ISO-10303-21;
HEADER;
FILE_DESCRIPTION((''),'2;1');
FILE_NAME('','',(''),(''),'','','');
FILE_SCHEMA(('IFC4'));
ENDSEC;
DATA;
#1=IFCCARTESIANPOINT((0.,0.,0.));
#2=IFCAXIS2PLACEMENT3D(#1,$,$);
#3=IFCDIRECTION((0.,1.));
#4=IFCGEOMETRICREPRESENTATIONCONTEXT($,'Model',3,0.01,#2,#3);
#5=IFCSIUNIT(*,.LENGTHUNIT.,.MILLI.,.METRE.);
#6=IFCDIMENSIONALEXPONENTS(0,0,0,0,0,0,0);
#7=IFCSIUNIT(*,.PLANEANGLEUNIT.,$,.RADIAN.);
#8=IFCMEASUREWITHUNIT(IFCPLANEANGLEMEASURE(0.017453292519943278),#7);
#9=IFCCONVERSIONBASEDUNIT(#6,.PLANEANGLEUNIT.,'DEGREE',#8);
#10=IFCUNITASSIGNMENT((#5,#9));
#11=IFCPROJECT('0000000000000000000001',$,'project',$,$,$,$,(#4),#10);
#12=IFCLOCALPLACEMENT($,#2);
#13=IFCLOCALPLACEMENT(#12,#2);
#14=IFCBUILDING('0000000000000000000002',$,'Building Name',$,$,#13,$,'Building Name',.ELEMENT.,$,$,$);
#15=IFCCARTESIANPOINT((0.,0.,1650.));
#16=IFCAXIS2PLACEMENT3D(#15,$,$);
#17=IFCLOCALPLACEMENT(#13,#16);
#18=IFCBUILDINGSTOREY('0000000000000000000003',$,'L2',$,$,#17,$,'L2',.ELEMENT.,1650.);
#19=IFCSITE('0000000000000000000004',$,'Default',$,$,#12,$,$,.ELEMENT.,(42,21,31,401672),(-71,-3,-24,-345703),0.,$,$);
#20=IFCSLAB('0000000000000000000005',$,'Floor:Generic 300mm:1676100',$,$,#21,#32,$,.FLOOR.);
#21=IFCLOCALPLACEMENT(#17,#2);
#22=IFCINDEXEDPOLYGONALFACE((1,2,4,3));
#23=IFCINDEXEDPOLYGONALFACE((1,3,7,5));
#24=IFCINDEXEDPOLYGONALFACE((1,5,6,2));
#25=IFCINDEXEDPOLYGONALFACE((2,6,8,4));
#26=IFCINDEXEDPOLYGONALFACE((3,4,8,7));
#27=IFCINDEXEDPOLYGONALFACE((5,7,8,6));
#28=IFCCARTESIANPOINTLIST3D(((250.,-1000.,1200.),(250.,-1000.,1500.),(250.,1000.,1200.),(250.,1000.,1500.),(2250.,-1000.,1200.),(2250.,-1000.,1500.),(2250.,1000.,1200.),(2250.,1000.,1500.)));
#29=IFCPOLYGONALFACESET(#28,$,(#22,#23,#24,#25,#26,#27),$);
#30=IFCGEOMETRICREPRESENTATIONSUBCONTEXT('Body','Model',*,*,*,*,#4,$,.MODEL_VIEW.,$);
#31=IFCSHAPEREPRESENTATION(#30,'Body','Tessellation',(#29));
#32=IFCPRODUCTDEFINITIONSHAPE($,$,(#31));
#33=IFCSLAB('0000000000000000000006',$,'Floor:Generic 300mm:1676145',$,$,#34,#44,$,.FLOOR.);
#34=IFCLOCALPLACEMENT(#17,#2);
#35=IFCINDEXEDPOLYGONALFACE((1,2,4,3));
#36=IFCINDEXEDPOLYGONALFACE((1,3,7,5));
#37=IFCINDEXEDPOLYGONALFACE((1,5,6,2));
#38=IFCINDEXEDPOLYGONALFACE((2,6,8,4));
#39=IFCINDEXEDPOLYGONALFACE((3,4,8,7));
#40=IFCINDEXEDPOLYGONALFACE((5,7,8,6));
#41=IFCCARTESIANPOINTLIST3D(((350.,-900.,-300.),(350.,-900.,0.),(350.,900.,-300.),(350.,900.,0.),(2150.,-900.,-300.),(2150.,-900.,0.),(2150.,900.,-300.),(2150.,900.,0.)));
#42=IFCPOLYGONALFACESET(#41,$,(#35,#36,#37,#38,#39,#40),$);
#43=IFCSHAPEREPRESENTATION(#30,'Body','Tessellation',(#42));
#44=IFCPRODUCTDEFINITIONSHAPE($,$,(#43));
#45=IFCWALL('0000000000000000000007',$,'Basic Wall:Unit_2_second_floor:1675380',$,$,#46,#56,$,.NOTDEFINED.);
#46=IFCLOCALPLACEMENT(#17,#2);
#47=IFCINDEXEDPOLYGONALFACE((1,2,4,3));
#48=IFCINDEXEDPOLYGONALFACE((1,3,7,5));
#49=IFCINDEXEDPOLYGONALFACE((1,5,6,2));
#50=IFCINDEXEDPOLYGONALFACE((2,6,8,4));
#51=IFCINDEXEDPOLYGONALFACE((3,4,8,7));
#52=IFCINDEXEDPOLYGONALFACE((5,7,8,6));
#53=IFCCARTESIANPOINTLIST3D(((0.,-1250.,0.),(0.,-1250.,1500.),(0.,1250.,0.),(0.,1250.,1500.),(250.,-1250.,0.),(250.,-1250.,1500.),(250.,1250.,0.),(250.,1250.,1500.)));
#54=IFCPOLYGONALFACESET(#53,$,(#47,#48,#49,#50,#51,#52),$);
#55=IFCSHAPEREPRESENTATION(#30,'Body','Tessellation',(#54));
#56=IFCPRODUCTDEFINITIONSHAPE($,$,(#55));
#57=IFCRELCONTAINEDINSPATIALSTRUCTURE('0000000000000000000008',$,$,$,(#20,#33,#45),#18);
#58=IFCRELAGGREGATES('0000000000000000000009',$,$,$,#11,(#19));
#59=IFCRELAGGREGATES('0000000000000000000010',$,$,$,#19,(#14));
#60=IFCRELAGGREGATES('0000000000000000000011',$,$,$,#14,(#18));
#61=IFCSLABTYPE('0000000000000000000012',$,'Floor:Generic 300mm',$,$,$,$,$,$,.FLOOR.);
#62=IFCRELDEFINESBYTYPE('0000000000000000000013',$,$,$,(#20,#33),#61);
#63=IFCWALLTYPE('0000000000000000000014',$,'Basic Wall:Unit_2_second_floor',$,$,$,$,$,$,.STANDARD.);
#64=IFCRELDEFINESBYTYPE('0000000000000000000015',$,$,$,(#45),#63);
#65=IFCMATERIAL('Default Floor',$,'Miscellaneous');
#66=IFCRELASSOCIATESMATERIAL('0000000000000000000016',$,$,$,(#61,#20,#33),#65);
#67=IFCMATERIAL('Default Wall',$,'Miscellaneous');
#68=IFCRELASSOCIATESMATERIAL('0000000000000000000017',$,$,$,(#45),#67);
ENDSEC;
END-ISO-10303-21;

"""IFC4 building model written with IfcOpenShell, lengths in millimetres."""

from ifc_helpers import new_model, entity, si_unit, converted_unit, direction, frame, origin, place, context, subcontext, project, spatial, indexed_curve, outline, extrude, material, type_object, element, save


model = new_model("IFC4")

# Units and contexts
model_context = context("Model", 3, precision=0.01, world=origin(), true_north=direction((0.0, 1.0)))
body_context = subcontext(model_context, "Body", "Model", "MODEL_VIEW")
ifc_project = project(units=[si_unit("LENGTHUNIT", "METRE", prefix="MILLI"), converted_unit("PLANEANGLEUNIT", "DEGREE", entity("IfcPlaneAngleMeasure", 0.017453292519943278), si_unit("PLANEANGLEUNIT", "RADIAN"), dimensions=[0, 0, 0, 0, 0, 0, 0])], contexts=[model_context])

# Site, building, storey
site_placement = place(None, origin())
site = spatial("IfcSite", under=ifc_project, at=site_placement, Name="Default", CompositionType="ELEMENT", RefLatitude=(42, 21, 31, 401672), RefLongitude=(-71, -3, -24, -345703), RefElevation=0.0)
building_placement = place(site_placement, origin())
building = spatial("IfcBuilding", under=site, at=building_placement, Name="Building Name", LongName="Building Name", CompositionType="ELEMENT")
storey_placement = place(building_placement, frame((0.0, 0.0, 1650.0)))
storey = spatial("IfcBuildingStorey", under=building, at=storey_placement, Name="L2", LongName="L2", CompositionType="ELEMENT", Elevation=1650.0)

# Slabs
ifc_material_1 = material(Name="Default Floor", Category="Miscellaneous")
slab_type = type_object("IfcSlabType", Name="Floor:Generic 300mm", PredefinedType="FLOOR", material=ifc_material_1)
slab_1_placement = place(storey_placement, origin())
element("IfcSlab", 1, at=slab_1_placement, inside=storey, type_object=slab_type, material=ifc_material_1, Name="Floor:Generic 300mm:1676100", PredefinedType="FLOOR", context=body_context, shape_type="SweptSolid", body=[
    extrude(outline(indexed_curve([(-1000.0, -1000.0), (1000.0, -1000.0), (1000.0, 1000.0), (-1000.0, 1000.0), (-1000.0, -1000.0)], self_intersect=False)), frame((1250.0, 0.0, 1500.0), z_axis=(0.0, 0.0, -1.0), x_axis=(0.0, 1.0, 0.0)), (0.0, 0.0, 1.0), 300.0),
])
slab_2_placement = place(storey_placement, origin())
element("IfcSlab", 2, at=slab_2_placement, inside=storey, type_object=slab_type, material=ifc_material_1, Name="Floor:Generic 300mm:1676145", PredefinedType="FLOOR", context=body_context, shape_type="SweptSolid", body=[
    extrude(outline(indexed_curve([(-900.0, -900.0), (900.0, -900.0), (900.0, 900.0), (-900.0, 900.0), (-900.0, -900.0)], self_intersect=False)), frame((1250.0, 0.0, 0.0), z_axis=(0.0, 0.0, -1.0), x_axis=(0.0, 1.0, 0.0)), (0.0, 0.0, 1.0), 300.0),
])

# Wall
ifc_material_2 = material(Name="Default Wall", Category="Miscellaneous")
wall_type = type_object("IfcWallType", Name="Basic Wall:Unit_2_second_floor", PredefinedType="STANDARD")
wall_placement = place(storey_placement, frame((125.0, 1250.0, 0.0), z_axis=(0.0, 0.0, 1.0), x_axis=(0.0, -1.0, 0.0)))
element("IfcWall", 3, at=wall_placement, inside=storey, type_object=wall_type, material=ifc_material_2, Name="Basic Wall:Unit_2_second_floor:1675380", PredefinedType="NOTDEFINED", context=body_context, shape_type="SweptSolid", body=[
    extrude(outline(indexed_curve([(2500.0, 125.0), (0.0, 125.0), (0.0, -125.0), (2500.0, -125.0), (2500.0, 125.0)], self_intersect=False)), origin(), (0.0, 0.0, 1.0), 1500.0),
])

save(model, "model.ifc")
